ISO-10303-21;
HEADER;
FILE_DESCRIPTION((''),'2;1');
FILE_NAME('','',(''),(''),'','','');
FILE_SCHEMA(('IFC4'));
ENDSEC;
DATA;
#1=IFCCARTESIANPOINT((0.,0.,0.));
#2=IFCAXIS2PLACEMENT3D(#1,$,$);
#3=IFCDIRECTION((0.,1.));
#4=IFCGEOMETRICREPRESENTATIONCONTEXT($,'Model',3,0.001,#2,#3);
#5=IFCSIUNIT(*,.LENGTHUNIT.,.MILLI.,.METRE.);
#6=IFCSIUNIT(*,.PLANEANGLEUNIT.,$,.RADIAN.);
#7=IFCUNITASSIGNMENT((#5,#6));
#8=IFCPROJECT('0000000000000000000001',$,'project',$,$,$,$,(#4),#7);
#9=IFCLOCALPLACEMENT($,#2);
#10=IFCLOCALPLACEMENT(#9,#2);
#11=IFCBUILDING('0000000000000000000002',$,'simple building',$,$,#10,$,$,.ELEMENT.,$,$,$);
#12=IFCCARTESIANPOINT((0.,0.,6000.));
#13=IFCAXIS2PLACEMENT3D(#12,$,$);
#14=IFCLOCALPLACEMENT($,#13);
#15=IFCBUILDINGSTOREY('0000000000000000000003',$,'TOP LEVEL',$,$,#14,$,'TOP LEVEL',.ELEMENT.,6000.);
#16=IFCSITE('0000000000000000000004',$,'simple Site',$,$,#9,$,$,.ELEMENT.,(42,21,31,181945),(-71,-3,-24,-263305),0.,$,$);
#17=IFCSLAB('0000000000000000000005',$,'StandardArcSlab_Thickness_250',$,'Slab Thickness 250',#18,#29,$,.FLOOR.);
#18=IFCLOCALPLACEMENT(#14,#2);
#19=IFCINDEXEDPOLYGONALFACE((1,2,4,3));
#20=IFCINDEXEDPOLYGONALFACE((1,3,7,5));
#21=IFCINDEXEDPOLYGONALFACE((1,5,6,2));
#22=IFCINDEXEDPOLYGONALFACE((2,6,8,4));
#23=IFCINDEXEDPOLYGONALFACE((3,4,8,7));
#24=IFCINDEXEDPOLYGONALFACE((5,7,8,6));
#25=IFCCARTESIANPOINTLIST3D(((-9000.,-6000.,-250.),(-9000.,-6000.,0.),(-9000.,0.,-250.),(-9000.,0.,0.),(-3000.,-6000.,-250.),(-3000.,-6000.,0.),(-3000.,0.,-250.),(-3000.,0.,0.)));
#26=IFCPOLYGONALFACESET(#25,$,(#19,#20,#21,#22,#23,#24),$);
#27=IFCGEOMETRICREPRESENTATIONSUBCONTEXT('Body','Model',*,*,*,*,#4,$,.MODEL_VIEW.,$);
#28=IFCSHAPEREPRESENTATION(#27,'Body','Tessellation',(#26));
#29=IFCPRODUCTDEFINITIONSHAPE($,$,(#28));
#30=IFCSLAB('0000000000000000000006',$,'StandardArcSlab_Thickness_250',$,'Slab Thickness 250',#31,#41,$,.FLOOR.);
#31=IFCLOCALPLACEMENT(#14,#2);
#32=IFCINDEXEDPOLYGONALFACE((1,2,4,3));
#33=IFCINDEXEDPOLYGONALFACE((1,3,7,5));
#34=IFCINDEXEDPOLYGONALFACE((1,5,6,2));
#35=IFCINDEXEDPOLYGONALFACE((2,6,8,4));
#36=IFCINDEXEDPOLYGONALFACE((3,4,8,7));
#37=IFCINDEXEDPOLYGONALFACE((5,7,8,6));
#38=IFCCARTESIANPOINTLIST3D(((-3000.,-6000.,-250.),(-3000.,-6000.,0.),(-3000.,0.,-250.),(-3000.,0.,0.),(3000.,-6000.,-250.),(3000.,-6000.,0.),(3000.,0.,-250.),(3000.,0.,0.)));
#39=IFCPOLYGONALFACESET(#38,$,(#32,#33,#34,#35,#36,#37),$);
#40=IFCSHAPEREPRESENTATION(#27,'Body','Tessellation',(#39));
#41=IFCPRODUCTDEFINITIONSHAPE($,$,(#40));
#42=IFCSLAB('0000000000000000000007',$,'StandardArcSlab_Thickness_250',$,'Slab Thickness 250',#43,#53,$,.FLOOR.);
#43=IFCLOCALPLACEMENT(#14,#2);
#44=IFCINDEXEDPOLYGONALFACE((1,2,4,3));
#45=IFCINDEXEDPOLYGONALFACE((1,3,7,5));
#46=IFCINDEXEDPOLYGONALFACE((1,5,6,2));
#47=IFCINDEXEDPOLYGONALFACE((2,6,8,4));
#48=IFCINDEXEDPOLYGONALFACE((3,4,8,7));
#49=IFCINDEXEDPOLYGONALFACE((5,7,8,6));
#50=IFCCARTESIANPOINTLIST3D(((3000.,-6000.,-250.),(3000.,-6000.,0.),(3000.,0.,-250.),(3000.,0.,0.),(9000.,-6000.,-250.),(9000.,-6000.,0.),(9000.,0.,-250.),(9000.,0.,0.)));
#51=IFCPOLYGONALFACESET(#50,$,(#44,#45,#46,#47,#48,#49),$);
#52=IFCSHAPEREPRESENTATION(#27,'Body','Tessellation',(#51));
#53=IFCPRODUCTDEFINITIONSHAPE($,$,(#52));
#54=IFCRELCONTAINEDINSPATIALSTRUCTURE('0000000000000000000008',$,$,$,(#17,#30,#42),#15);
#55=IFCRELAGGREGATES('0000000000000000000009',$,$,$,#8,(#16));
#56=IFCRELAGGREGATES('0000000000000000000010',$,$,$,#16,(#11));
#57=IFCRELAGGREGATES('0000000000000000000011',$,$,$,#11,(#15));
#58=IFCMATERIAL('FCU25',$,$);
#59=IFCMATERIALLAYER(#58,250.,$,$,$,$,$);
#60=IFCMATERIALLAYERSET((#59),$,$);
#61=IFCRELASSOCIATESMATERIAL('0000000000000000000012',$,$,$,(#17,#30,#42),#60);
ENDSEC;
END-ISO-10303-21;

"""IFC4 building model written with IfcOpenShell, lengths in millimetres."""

from ifc_helpers import new_model, si_unit, direction, frame, origin, origin_with_axes, place, context, subcontext, project, spatial, polyline, outline, extrude, material, layer, layer_set, layer_usage, element, save


model = new_model("IFC4")

# Units and contexts
model_context = context("Model", 3, precision=0.001, world=origin(), true_north=direction((0.0, 1.0)))
body_context = subcontext(model_context, "Body", "Model", "MODEL_VIEW")
ifc_project = project(units=[si_unit("LENGTHUNIT", "METRE", prefix="MILLI"), si_unit("PLANEANGLEUNIT", "RADIAN")], contexts=[model_context])

# Site, building, storey
site_placement = place(None, origin())
site = spatial("IfcSite", under=ifc_project, at=site_placement, Name="simple Site", CompositionType="ELEMENT", RefLatitude=(42, 21, 31, 181945), RefLongitude=(-71, -3, -24, -263305), RefElevation=0.0)
building_placement = place(site_placement, origin())
building = spatial("IfcBuilding", under=site, at=building_placement, Name="simple building", CompositionType="ELEMENT")
storey_placement = place(None, frame((0.0, 0.0, 6000.0)))
storey = spatial("IfcBuildingStorey", under=building, at=storey_placement, Name="TOP LEVEL", LongName="TOP LEVEL", CompositionType="ELEMENT", Elevation=6000.0)

# Shared definitions
ifc_material = material(Name="FCU25")

# Slabs
ifc_layer = layer(ifc_material, 250.0)
ifc_layer_set = layer_set([ifc_layer])
ifc_layer_usage = layer_usage(ifc_layer_set, "AXIS3", "POSITIVE", -250.0)
for number, where, z_axis, x_axis, name in (
    (1, (-9000.0, -6000.0, 5750.0), (0.0, 0.0, 1.0), (1.0, 0.0, 0.0), "StandardArcSlab_Thickness_250"),
    (2, (-3000.0, -6000.0, 5750.0), (0.0, 0.0, 1.0), (1.0, 0.0, 0.0), "StandardArcSlab_Thickness_250"),
    (3, (3000.0, -6000.0, 5750.0), (0.0, 0.0, 1.0), (1.0, 0.0, 0.0), "StandardArcSlab_Thickness_250"),
):
    element("IfcSlab", number, at=place(None, frame(where, z_axis=z_axis, x_axis=x_axis)), inside=storey, material=ifc_layer_usage, Name=name, ObjectType="Slab Thickness 250", PredefinedType="FLOOR", context=body_context, shape_type="SweptSolid", body=[
        extrude(outline(polyline([(0.0, 0.0), (6000.0, 0.0), (6000.0, 6000.0), (0.0, 6000.0), (0.0, 0.0)])), origin_with_axes(), (0.0, 0.0, 1.0), 250.0),
    ])

save(model, "model.ifc")
